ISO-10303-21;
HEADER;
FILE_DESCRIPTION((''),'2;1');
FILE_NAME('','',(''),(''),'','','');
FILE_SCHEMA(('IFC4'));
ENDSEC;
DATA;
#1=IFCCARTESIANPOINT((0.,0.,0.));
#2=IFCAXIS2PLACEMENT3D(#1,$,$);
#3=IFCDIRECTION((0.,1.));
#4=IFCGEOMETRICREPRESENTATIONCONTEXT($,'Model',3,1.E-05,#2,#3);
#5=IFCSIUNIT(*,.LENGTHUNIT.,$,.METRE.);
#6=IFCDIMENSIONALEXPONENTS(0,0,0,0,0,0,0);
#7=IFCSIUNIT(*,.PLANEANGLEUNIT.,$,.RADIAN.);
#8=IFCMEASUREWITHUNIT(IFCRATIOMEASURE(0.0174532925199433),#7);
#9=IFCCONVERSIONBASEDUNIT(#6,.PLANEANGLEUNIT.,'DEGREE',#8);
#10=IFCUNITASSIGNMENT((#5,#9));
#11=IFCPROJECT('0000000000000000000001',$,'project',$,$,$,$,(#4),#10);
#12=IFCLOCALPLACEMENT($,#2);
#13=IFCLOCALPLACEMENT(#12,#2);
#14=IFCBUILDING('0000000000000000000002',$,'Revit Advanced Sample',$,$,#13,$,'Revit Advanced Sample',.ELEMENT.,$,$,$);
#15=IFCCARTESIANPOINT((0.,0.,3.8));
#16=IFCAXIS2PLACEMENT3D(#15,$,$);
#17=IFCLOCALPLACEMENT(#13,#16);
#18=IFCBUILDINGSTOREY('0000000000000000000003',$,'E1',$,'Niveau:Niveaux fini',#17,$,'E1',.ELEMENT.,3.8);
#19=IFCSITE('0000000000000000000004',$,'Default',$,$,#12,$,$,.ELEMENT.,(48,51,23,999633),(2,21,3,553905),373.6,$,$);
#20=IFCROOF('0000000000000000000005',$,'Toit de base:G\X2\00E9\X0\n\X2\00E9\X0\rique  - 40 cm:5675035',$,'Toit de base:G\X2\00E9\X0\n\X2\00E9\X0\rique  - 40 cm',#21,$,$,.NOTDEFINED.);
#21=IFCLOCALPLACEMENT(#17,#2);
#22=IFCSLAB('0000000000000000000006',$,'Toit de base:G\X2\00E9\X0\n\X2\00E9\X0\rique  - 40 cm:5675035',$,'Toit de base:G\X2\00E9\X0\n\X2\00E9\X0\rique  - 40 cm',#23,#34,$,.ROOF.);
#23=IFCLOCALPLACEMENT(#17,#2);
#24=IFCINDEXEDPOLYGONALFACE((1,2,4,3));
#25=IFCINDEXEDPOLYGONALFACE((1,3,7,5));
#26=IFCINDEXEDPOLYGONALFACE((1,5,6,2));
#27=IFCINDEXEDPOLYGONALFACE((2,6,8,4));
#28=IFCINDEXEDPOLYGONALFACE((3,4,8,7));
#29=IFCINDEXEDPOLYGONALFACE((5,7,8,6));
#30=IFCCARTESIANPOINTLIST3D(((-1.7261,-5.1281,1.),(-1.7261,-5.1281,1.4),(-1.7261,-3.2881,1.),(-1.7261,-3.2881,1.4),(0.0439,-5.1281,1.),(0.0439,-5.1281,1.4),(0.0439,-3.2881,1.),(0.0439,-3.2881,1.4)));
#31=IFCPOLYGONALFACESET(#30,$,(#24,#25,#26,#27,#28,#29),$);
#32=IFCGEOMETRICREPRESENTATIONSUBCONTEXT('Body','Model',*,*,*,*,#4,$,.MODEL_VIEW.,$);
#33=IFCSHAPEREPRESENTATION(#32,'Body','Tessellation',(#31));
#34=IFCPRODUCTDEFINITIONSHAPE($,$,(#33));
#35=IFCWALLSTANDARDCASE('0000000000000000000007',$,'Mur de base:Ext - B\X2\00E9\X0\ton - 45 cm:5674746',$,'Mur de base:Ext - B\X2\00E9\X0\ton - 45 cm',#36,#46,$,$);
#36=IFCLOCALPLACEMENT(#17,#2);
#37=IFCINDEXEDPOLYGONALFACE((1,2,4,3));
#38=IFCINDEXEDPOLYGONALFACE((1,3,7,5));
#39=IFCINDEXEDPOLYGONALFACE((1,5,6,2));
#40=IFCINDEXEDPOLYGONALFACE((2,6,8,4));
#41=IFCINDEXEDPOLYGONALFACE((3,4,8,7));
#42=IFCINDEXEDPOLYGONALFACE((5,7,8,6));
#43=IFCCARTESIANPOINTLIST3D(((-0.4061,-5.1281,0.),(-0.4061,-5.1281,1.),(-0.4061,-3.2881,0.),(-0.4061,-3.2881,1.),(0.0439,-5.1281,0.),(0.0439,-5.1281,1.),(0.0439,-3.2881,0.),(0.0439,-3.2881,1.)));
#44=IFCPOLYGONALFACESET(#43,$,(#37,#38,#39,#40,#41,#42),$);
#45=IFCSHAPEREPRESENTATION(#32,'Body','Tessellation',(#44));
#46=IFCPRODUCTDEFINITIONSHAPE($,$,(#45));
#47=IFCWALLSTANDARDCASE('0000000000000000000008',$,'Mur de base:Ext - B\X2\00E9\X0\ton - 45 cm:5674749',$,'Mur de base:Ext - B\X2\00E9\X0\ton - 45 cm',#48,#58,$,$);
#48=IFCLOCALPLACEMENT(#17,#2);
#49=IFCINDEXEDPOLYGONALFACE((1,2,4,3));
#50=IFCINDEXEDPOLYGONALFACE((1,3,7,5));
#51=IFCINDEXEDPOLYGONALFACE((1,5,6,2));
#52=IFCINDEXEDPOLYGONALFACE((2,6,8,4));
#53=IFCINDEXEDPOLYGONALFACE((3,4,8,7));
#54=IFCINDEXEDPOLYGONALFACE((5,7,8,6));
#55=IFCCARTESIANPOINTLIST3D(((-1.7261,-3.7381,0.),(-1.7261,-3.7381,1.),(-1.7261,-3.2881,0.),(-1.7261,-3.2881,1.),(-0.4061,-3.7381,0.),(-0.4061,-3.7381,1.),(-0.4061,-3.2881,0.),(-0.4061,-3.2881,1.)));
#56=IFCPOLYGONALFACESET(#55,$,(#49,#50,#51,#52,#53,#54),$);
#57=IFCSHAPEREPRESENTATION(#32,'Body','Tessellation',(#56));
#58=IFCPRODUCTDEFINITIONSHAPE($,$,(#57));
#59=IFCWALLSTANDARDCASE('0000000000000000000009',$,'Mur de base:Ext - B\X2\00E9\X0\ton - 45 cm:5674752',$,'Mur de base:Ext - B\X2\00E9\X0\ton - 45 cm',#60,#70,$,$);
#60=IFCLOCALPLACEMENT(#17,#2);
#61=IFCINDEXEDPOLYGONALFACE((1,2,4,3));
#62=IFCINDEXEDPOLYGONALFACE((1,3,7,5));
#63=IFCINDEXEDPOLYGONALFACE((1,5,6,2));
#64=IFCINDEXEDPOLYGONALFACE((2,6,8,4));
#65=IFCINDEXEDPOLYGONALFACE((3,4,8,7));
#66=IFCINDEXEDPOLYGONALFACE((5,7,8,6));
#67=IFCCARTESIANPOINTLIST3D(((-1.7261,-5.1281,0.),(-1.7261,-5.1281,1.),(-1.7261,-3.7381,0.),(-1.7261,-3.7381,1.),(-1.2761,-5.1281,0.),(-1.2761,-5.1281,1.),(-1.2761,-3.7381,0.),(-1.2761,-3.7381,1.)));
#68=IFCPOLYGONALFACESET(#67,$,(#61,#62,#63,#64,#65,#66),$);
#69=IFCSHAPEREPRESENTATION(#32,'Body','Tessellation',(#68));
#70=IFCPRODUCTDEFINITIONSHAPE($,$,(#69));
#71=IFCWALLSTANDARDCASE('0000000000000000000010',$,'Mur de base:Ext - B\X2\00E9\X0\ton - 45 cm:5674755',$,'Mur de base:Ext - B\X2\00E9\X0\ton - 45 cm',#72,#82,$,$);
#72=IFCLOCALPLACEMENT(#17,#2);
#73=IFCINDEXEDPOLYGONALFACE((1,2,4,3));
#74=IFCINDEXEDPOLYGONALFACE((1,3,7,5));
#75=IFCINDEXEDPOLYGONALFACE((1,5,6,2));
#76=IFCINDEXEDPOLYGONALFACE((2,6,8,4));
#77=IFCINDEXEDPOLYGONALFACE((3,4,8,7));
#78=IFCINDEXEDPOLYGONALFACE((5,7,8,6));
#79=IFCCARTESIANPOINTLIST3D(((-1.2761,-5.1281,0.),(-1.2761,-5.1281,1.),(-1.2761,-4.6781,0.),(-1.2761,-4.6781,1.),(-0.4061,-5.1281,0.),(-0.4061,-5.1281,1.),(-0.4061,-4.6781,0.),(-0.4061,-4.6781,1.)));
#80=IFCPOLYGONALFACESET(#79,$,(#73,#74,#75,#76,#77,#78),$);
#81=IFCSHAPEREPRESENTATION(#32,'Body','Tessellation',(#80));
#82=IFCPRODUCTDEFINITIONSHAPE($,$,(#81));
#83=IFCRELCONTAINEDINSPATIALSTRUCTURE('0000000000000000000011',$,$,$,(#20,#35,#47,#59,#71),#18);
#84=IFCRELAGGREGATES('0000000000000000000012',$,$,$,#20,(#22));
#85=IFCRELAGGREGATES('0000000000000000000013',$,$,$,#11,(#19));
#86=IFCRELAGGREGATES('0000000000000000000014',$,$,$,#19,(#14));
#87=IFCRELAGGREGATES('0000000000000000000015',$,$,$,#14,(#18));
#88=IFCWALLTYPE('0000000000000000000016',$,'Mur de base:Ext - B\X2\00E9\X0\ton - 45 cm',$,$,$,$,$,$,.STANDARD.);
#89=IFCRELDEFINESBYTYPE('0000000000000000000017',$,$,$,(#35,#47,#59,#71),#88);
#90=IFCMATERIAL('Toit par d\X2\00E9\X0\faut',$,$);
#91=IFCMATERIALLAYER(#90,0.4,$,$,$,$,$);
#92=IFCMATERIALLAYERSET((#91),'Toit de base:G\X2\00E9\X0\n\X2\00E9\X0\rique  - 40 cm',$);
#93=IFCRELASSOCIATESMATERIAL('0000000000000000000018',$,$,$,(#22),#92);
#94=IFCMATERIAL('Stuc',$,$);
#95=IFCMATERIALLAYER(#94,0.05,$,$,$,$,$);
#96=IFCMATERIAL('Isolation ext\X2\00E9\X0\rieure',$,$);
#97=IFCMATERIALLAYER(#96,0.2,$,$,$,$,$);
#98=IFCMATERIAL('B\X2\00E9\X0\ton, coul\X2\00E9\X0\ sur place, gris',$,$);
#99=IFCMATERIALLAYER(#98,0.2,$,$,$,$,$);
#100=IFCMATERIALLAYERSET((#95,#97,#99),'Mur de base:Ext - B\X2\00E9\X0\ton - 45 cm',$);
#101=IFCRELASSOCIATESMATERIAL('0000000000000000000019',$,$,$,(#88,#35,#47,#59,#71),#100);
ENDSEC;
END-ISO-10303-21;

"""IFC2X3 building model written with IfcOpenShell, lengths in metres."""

from ifc_helpers import new_model, entity, si_unit, converted_unit, direction, frame, frame_2d, origin, place, context, subcontext, project, spatial, rectangle, extrude, material, layer, layer_set, layer_usage, type_object, element, aggregate, save


model = new_model("IFC2X3")

# Units and contexts
model_context = context("Model", 3, precision=1e-05, world=origin(), true_north=direction((0.0, 1.0)))
body_context = subcontext(model_context, "Body", "Model", "MODEL_VIEW")
ifc_project = project(units=[si_unit("LENGTHUNIT", "METRE"), converted_unit("PLANEANGLEUNIT", "DEGREE", entity("IfcRatioMeasure", 0.0174532925199433), si_unit("PLANEANGLEUNIT", "RADIAN"), dimensions=[0, 0, 0, 0, 0, 0, 0])], contexts=[model_context])

# Site, building, storey
site_placement = place(None, origin())
site = spatial("IfcSite", under=ifc_project, at=site_placement, Name="Default", CompositionType="ELEMENT", RefLatitude=(48, 51, 23, 999633), RefLongitude=(2, 21, 3, 553905), RefElevation=373.6)
building_placement = place(site_placement, origin())
building = spatial("IfcBuilding", under=site, at=building_placement, Name="Revit Advanced Sample", LongName="Revit Advanced Sample", CompositionType="ELEMENT")
storey_placement = place(building_placement, frame((0.0, 0.0, 3.8)))
storey = spatial("IfcBuildingStorey", under=building, at=storey_placement, Name="E1", ObjectType="Niveau:Niveaux fini", LongName="E1", CompositionType="ELEMENT", Elevation=3.8)

# Roof, slab
roof_1_placement = place(storey_placement, frame((-1.7261, -5.1281, 1.0)))
roof_1 = element("IfcRoof", 1, at=roof_1_placement, inside=storey, Name="Toit de base:Générique  - 40 cm:5675035", ObjectType="Toit de base:Générique  - 40 cm", ShapeType="NOTDEFINED")
ifc_material_1 = material(Name="Toit par défaut")
ifc_layer_1 = layer(ifc_material_1, 0.4)
ifc_layer_set_1 = layer_set([ifc_layer_1], Name="Toit de base:Générique  - 40 cm")
slab_1_placement = place(roof_1_placement, origin())
slab_1 = element("IfcSlab", 2, at=slab_1_placement, material=ifc_layer_set_1, Name="Toit de base:Générique  - 40 cm:5675035", ObjectType="Toit de base:Générique  - 40 cm", PredefinedType="ROOF", context=body_context, shape_type="SweptSolid", body=[
    extrude(rectangle(XDim=1.84, YDim=1.77, at=frame_2d((0.0, 0.0), x_axis=(0.0, -1.0))), frame((0.885, 0.92, 0.0)), (0.0, 0.0, 1.0), 0.4),
])
aggregate(roof_1, [slab_1])

# Walls
ifc_material_2 = material(Name="Stuc")
ifc_layer_2 = layer(ifc_material_2, 0.05)
ifc_material_3 = material(Name="Isolation extérieure")
ifc_layer_3 = layer(ifc_material_3, 0.2)
ifc_material_4 = material(Name="Béton, coulé sur place, gris")
ifc_layer_4 = layer(ifc_material_4, 0.2)
ifc_layer_set_2 = layer_set([ifc_layer_2, ifc_layer_3, ifc_layer_4], Name="Mur de base:Ext - Béton - 45 cm")
ifc_layer_usage_1 = layer_usage(ifc_layer_set_2, "AXIS2", "NEGATIVE", 0.225)
wall_type = type_object("IfcWallType", Name="Mur de base:Ext - Béton - 45 cm", PredefinedType="STANDARD", material=ifc_layer_set_2)
wall_1_placement = place(storey_placement, frame((-0.1811, -5.1281, 0.0), z_axis=(0.0, 0.0, 1.0), x_axis=(0.0, 1.0, 0.0)))
element("IfcWallStandardCase", 3, at=wall_1_placement, inside=storey, type_object=wall_type, material=ifc_layer_usage_1, Name="Mur de base:Ext - Béton - 45 cm:5674746", ObjectType="Mur de base:Ext - Béton - 45 cm", context=body_context, shape_type="SweptSolid", body=[
    extrude(rectangle(XDim=1.84, YDim=0.45, at=frame_2d((0.92, 0.0), x_axis=(-1.0, 0.0))), origin(), (0.0, 0.0, 1.0), 1.0),
])
ifc_layer_usage_2 = layer_usage(ifc_layer_set_2, "AXIS2", "NEGATIVE", 0.225)
wall_2_placement = place(storey_placement, frame((-0.4061, -3.5131, 0.0), z_axis=(0.0, 0.0, 1.0), x_axis=(-1.0, 0.0, 0.0)))
element("IfcWallStandardCase", 4, at=wall_2_placement, inside=storey, type_object=wall_type, material=ifc_layer_usage_2, Name="Mur de base:Ext - Béton - 45 cm:5674749", ObjectType="Mur de base:Ext - Béton - 45 cm", context=body_context, shape_type="SweptSolid", body=[
    extrude(rectangle(XDim=1.32, YDim=0.45, at=frame_2d((0.66, 0.0), x_axis=(-1.0, 0.0))), origin(), (0.0, 0.0, 1.0), 1.0),
])
ifc_layer_usage_3 = layer_usage(ifc_layer_set_2, "AXIS2", "NEGATIVE", 0.225)
wall_3_placement = place(storey_placement, frame((-1.5011, -3.7381, 0.0), z_axis=(0.0, 0.0, 1.0), x_axis=(0.0, -1.0, 0.0)))
element("IfcWallStandardCase", 5, at=wall_3_placement, inside=storey, type_object=wall_type, material=ifc_layer_usage_3, Name="Mur de base:Ext - Béton - 45 cm:5674752", ObjectType="Mur de base:Ext - Béton - 45 cm", context=body_context, shape_type="SweptSolid", body=[
    extrude(rectangle(XDim=1.39, YDim=0.45, at=frame_2d((0.695, 0.0), x_axis=(-1.0, 0.0))), origin(), (0.0, 0.0, 1.0), 1.0),
])
ifc_layer_usage_4 = layer_usage(ifc_layer_set_2, "AXIS2", "NEGATIVE", 0.225)
wall_4_placement = place(storey_placement, frame((-1.2761, -4.9031, 0.0)))
element("IfcWallStandardCase", 6, at=wall_4_placement, inside=storey, type_object=wall_type, material=ifc_layer_usage_4, Name="Mur de base:Ext - Béton - 45 cm:5674755", ObjectType="Mur de base:Ext - Béton - 45 cm", context=body_context, shape_type="SweptSolid", body=[
    extrude(rectangle(XDim=0.87, YDim=0.45, at=frame_2d((0.435, 0.0), x_axis=(-1.0, 0.0))), origin(), (0.0, 0.0, 1.0), 1.0),
])

save(model, "model.ifc")
